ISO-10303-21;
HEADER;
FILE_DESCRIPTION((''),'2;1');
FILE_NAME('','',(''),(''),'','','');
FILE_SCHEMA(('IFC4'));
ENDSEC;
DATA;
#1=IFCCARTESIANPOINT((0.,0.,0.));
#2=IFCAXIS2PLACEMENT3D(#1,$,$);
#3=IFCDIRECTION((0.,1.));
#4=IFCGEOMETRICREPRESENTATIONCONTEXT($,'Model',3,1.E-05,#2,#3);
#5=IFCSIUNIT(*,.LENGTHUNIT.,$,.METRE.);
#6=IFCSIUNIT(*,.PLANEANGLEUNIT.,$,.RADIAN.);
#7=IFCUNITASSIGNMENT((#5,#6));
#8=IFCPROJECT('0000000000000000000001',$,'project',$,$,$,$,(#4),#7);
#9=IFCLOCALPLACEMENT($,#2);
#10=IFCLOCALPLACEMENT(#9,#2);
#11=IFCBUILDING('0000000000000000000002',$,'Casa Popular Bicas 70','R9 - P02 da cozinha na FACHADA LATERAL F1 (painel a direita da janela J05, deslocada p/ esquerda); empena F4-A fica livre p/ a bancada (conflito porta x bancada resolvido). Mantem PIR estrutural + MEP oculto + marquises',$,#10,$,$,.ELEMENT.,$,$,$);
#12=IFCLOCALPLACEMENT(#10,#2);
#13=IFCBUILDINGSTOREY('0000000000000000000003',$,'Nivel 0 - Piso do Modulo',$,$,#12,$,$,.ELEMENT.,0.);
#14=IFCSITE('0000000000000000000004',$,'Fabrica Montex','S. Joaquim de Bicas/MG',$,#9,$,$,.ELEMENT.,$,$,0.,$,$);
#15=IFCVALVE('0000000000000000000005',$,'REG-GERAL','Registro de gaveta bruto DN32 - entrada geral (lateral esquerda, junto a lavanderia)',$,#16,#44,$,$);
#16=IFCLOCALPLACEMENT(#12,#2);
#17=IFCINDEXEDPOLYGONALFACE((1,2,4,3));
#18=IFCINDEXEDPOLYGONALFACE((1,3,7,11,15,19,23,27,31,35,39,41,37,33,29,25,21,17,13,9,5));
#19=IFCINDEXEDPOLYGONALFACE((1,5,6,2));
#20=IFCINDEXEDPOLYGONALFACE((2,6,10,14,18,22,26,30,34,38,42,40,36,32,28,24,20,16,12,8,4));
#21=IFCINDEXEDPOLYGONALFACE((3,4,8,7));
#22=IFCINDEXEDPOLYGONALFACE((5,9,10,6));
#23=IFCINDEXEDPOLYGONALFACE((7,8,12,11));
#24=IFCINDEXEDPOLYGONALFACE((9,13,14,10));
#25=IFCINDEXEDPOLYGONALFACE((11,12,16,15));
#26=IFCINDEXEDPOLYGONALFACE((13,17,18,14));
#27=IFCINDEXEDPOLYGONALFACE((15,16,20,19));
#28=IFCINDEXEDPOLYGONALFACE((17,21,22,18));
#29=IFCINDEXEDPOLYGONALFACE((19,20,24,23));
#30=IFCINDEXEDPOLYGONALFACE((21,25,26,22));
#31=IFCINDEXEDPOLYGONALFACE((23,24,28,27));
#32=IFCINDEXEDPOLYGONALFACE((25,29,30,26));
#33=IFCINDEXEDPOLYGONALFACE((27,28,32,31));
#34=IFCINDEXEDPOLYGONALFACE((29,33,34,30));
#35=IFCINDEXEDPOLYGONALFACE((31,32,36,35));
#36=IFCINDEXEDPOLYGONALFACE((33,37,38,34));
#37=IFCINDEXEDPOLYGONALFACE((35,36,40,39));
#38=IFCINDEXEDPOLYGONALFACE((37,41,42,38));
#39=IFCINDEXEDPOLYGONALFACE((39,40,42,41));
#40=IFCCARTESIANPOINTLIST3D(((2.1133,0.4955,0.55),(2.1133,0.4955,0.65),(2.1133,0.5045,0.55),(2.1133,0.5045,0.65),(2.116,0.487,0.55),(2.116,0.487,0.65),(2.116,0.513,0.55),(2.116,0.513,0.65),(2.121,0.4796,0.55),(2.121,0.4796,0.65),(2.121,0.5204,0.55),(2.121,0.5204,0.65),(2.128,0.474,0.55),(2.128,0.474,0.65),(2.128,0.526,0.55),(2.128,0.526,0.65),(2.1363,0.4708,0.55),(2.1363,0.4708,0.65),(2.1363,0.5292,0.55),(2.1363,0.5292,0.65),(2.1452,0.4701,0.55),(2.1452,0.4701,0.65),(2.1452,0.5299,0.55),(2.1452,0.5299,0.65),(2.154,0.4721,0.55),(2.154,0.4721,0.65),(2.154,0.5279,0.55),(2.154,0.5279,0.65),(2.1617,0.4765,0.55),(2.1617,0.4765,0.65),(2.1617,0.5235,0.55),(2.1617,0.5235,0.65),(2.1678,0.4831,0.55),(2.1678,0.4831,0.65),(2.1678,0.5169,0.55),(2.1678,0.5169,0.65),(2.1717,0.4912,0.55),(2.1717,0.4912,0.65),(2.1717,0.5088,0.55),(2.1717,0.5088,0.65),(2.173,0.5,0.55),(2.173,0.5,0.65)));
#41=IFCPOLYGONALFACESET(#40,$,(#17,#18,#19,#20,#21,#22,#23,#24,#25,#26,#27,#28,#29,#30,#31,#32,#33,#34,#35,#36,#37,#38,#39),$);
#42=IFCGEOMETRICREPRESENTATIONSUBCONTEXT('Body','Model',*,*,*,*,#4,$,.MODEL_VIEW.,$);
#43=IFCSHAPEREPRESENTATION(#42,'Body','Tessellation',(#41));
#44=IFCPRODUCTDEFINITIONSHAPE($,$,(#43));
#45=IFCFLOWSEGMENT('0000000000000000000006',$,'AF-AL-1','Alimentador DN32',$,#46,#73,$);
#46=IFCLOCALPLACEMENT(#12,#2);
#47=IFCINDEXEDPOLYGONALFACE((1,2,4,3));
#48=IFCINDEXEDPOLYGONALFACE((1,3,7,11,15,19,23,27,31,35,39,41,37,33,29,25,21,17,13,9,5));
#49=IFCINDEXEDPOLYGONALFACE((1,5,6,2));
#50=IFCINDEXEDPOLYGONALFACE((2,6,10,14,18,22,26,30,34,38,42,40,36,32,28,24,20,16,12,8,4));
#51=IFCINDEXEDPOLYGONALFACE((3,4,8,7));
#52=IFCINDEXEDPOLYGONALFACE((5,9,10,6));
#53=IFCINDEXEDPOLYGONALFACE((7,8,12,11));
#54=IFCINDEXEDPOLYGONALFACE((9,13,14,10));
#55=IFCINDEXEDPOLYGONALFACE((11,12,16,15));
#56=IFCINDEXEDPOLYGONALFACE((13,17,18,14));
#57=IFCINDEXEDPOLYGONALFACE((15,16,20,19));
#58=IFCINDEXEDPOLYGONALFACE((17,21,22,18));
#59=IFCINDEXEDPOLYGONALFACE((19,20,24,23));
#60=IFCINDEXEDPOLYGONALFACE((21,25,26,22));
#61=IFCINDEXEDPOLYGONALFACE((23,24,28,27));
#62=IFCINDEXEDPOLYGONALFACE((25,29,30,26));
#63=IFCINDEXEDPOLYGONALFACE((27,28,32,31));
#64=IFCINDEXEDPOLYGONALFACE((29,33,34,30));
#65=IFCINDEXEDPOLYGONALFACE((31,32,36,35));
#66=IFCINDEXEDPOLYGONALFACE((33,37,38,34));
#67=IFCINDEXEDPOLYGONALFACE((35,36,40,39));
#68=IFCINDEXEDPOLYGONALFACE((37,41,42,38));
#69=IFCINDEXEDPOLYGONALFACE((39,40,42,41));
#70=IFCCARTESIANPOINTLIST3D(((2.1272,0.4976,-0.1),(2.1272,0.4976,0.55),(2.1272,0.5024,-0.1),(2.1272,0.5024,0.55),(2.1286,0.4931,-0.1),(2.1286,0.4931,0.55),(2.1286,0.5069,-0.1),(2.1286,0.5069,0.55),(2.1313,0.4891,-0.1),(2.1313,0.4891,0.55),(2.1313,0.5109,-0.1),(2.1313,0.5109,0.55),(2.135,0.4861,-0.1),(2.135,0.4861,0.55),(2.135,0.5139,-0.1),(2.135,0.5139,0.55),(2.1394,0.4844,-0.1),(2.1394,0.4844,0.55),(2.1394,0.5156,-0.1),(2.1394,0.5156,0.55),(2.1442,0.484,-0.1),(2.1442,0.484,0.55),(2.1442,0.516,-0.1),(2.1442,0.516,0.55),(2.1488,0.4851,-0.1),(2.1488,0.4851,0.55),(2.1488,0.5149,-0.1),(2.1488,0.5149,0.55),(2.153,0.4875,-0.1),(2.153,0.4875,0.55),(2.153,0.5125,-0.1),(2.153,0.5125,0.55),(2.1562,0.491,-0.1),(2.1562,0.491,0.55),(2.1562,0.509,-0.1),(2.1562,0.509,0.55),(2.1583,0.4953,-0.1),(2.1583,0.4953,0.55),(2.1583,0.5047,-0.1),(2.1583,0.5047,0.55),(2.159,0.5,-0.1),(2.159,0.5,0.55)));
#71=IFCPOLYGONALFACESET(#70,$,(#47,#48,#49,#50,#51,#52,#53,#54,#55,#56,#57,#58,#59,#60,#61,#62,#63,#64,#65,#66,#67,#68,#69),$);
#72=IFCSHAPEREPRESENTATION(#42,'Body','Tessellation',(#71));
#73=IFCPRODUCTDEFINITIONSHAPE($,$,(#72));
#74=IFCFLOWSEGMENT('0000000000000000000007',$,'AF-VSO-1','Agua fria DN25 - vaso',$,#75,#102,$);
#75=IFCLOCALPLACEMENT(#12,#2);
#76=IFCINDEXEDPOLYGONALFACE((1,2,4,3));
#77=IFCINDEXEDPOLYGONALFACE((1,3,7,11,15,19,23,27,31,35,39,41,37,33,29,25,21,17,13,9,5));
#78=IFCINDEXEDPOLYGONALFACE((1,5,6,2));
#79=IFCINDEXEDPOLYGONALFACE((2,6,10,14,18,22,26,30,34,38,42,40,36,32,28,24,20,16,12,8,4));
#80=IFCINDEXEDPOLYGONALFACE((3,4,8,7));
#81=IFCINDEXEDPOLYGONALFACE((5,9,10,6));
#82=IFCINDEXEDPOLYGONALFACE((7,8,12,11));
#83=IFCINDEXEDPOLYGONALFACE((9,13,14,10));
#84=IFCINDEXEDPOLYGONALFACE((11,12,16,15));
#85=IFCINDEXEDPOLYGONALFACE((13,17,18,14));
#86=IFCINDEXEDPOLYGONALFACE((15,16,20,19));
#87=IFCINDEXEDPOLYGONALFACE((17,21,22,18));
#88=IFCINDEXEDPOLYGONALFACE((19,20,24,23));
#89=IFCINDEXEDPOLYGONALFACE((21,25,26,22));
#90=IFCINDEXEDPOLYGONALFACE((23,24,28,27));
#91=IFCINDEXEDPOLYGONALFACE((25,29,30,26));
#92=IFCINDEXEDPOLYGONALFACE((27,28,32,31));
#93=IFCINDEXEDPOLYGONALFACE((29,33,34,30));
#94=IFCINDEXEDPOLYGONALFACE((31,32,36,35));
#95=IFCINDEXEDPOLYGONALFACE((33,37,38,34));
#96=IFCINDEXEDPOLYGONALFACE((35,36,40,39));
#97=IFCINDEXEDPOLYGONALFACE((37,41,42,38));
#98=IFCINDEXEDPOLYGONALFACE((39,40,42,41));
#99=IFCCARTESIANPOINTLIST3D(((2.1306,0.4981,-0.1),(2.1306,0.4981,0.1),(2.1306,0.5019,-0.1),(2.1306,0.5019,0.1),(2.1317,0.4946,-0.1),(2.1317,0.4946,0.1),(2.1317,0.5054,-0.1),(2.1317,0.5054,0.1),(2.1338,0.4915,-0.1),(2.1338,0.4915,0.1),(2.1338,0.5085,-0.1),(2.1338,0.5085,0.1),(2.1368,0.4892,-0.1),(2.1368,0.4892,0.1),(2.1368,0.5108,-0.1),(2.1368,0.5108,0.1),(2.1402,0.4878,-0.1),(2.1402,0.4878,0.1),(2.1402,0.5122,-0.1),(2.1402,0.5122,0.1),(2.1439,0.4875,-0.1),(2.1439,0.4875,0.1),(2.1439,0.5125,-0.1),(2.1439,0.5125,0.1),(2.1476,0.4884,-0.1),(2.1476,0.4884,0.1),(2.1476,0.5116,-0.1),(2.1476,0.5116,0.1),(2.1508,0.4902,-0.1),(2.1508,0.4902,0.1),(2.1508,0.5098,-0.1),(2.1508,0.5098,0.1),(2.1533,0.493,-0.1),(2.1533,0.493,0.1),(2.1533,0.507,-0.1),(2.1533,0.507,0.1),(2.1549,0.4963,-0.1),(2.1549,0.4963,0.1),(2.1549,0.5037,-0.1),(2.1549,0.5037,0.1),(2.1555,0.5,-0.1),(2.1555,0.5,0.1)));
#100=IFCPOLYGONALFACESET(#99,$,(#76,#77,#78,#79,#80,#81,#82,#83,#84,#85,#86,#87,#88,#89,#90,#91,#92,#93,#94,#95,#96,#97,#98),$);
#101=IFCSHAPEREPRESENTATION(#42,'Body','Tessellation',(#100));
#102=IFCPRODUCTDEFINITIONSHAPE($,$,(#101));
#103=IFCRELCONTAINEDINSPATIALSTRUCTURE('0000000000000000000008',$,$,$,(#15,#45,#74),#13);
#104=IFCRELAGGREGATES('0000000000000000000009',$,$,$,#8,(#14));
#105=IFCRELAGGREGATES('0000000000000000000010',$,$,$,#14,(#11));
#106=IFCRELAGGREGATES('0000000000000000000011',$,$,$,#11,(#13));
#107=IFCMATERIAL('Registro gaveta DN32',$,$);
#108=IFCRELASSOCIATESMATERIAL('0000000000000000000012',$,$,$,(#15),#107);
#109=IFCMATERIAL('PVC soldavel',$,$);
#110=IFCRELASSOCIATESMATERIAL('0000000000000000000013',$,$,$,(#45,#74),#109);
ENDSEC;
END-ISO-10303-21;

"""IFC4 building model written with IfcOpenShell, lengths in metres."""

from ifc_helpers import new_model, si_unit, direction, frame, origin, origin_2d, place, context, subcontext, project, spatial, circle, extrude, material, element, save


model = new_model("IFC4")

# Units and contexts
model_context = context("Model", 3, precision=1e-05, world=origin(), true_north=direction((0.0, 1.0)))
body_context = subcontext(model_context, "Body", "Model", "MODEL_VIEW")
ifc_project = project(units=[si_unit("LENGTHUNIT", "METRE"), si_unit("PLANEANGLEUNIT", "RADIAN")], contexts=[model_context])

# Site, building, storey
site_placement = place(None, origin())
site = spatial("IfcSite", under=ifc_project, at=site_placement, Name="Fabrica Montex", Description="S. Joaquim de Bicas/MG", CompositionType="ELEMENT", RefElevation=0.0)
building_placement = place(site_placement, origin())
building = spatial("IfcBuilding", under=site, at=building_placement, Name="Casa Popular Bicas 70", Description="R9 - P02 da cozinha na FACHADA LATERAL F1 (painel a direita da janela J05, deslocada p/ esquerda); empena F4-A fica livre p/ a bancada (conflito porta x bancada resolvido). Mantem PIR estrutural + MEP oculto + marquises", CompositionType="ELEMENT")
storey_placement = place(building_placement, origin())
storey = spatial("IfcBuildingStorey", under=building, at=storey_placement, Name="Nivel 0 - Piso do Modulo", CompositionType="ELEMENT", Elevation=0.0)

# Valve
ifc_material_1 = material(Name="Registro gaveta DN32")
valve_placement = place(storey_placement, frame((2.143, 0.5, 0.55)))
element("IfcValve", 1, at=valve_placement, inside=storey, material=ifc_material_1, Name="REG-GERAL", Description="Registro de gaveta bruto DN32 - entrada geral (lateral esquerda, junto a lavanderia)", context=body_context, shape_type="SweptSolid", body=[
    extrude(circle(Radius=0.03, at=origin_2d()), origin(), (0.0, 0.0, 1.0), 0.1),
])

# Flow segments
ifc_material_2 = material(Name="PVC soldavel")
flow_segment_placement = place(storey_placement, frame((2.143, 0.5, 0.55), z_axis=(0.0, 0.0, -1.0), x_axis=(1.0, 0.0, 0.0)))
element("IfcFlowSegment", 2, at=flow_segment_placement, inside=storey, material=ifc_material_2, Name="AF-AL-1", Description="Alimentador DN32", context=body_context, shape_type="SweptSolid", body=[
    extrude(circle(Radius=0.016, at=origin_2d()), origin(), (0.0, 0.0, 1.0), 0.65),
])
for number, where, z_axis, x_axis, name in (
    (3, (2.143, 0.5, 0.1), (0.0, 0.0, -1.0), (1.0, 0.0, 0.0), "AF-VSO-1"),
):
    element("IfcFlowSegment", number, at=place(storey_placement, frame(where, z_axis=z_axis, x_axis=x_axis)), inside=storey, material=ifc_material_2, Name=name, Description="Agua fria DN25 - vaso", context=body_context, shape_type="SweptSolid", body=[
        extrude(circle(Radius=0.0125, at=origin_2d()), origin(), (0.0, 0.0, 1.0), 0.2),
    ])

save(model, "model.ifc")
